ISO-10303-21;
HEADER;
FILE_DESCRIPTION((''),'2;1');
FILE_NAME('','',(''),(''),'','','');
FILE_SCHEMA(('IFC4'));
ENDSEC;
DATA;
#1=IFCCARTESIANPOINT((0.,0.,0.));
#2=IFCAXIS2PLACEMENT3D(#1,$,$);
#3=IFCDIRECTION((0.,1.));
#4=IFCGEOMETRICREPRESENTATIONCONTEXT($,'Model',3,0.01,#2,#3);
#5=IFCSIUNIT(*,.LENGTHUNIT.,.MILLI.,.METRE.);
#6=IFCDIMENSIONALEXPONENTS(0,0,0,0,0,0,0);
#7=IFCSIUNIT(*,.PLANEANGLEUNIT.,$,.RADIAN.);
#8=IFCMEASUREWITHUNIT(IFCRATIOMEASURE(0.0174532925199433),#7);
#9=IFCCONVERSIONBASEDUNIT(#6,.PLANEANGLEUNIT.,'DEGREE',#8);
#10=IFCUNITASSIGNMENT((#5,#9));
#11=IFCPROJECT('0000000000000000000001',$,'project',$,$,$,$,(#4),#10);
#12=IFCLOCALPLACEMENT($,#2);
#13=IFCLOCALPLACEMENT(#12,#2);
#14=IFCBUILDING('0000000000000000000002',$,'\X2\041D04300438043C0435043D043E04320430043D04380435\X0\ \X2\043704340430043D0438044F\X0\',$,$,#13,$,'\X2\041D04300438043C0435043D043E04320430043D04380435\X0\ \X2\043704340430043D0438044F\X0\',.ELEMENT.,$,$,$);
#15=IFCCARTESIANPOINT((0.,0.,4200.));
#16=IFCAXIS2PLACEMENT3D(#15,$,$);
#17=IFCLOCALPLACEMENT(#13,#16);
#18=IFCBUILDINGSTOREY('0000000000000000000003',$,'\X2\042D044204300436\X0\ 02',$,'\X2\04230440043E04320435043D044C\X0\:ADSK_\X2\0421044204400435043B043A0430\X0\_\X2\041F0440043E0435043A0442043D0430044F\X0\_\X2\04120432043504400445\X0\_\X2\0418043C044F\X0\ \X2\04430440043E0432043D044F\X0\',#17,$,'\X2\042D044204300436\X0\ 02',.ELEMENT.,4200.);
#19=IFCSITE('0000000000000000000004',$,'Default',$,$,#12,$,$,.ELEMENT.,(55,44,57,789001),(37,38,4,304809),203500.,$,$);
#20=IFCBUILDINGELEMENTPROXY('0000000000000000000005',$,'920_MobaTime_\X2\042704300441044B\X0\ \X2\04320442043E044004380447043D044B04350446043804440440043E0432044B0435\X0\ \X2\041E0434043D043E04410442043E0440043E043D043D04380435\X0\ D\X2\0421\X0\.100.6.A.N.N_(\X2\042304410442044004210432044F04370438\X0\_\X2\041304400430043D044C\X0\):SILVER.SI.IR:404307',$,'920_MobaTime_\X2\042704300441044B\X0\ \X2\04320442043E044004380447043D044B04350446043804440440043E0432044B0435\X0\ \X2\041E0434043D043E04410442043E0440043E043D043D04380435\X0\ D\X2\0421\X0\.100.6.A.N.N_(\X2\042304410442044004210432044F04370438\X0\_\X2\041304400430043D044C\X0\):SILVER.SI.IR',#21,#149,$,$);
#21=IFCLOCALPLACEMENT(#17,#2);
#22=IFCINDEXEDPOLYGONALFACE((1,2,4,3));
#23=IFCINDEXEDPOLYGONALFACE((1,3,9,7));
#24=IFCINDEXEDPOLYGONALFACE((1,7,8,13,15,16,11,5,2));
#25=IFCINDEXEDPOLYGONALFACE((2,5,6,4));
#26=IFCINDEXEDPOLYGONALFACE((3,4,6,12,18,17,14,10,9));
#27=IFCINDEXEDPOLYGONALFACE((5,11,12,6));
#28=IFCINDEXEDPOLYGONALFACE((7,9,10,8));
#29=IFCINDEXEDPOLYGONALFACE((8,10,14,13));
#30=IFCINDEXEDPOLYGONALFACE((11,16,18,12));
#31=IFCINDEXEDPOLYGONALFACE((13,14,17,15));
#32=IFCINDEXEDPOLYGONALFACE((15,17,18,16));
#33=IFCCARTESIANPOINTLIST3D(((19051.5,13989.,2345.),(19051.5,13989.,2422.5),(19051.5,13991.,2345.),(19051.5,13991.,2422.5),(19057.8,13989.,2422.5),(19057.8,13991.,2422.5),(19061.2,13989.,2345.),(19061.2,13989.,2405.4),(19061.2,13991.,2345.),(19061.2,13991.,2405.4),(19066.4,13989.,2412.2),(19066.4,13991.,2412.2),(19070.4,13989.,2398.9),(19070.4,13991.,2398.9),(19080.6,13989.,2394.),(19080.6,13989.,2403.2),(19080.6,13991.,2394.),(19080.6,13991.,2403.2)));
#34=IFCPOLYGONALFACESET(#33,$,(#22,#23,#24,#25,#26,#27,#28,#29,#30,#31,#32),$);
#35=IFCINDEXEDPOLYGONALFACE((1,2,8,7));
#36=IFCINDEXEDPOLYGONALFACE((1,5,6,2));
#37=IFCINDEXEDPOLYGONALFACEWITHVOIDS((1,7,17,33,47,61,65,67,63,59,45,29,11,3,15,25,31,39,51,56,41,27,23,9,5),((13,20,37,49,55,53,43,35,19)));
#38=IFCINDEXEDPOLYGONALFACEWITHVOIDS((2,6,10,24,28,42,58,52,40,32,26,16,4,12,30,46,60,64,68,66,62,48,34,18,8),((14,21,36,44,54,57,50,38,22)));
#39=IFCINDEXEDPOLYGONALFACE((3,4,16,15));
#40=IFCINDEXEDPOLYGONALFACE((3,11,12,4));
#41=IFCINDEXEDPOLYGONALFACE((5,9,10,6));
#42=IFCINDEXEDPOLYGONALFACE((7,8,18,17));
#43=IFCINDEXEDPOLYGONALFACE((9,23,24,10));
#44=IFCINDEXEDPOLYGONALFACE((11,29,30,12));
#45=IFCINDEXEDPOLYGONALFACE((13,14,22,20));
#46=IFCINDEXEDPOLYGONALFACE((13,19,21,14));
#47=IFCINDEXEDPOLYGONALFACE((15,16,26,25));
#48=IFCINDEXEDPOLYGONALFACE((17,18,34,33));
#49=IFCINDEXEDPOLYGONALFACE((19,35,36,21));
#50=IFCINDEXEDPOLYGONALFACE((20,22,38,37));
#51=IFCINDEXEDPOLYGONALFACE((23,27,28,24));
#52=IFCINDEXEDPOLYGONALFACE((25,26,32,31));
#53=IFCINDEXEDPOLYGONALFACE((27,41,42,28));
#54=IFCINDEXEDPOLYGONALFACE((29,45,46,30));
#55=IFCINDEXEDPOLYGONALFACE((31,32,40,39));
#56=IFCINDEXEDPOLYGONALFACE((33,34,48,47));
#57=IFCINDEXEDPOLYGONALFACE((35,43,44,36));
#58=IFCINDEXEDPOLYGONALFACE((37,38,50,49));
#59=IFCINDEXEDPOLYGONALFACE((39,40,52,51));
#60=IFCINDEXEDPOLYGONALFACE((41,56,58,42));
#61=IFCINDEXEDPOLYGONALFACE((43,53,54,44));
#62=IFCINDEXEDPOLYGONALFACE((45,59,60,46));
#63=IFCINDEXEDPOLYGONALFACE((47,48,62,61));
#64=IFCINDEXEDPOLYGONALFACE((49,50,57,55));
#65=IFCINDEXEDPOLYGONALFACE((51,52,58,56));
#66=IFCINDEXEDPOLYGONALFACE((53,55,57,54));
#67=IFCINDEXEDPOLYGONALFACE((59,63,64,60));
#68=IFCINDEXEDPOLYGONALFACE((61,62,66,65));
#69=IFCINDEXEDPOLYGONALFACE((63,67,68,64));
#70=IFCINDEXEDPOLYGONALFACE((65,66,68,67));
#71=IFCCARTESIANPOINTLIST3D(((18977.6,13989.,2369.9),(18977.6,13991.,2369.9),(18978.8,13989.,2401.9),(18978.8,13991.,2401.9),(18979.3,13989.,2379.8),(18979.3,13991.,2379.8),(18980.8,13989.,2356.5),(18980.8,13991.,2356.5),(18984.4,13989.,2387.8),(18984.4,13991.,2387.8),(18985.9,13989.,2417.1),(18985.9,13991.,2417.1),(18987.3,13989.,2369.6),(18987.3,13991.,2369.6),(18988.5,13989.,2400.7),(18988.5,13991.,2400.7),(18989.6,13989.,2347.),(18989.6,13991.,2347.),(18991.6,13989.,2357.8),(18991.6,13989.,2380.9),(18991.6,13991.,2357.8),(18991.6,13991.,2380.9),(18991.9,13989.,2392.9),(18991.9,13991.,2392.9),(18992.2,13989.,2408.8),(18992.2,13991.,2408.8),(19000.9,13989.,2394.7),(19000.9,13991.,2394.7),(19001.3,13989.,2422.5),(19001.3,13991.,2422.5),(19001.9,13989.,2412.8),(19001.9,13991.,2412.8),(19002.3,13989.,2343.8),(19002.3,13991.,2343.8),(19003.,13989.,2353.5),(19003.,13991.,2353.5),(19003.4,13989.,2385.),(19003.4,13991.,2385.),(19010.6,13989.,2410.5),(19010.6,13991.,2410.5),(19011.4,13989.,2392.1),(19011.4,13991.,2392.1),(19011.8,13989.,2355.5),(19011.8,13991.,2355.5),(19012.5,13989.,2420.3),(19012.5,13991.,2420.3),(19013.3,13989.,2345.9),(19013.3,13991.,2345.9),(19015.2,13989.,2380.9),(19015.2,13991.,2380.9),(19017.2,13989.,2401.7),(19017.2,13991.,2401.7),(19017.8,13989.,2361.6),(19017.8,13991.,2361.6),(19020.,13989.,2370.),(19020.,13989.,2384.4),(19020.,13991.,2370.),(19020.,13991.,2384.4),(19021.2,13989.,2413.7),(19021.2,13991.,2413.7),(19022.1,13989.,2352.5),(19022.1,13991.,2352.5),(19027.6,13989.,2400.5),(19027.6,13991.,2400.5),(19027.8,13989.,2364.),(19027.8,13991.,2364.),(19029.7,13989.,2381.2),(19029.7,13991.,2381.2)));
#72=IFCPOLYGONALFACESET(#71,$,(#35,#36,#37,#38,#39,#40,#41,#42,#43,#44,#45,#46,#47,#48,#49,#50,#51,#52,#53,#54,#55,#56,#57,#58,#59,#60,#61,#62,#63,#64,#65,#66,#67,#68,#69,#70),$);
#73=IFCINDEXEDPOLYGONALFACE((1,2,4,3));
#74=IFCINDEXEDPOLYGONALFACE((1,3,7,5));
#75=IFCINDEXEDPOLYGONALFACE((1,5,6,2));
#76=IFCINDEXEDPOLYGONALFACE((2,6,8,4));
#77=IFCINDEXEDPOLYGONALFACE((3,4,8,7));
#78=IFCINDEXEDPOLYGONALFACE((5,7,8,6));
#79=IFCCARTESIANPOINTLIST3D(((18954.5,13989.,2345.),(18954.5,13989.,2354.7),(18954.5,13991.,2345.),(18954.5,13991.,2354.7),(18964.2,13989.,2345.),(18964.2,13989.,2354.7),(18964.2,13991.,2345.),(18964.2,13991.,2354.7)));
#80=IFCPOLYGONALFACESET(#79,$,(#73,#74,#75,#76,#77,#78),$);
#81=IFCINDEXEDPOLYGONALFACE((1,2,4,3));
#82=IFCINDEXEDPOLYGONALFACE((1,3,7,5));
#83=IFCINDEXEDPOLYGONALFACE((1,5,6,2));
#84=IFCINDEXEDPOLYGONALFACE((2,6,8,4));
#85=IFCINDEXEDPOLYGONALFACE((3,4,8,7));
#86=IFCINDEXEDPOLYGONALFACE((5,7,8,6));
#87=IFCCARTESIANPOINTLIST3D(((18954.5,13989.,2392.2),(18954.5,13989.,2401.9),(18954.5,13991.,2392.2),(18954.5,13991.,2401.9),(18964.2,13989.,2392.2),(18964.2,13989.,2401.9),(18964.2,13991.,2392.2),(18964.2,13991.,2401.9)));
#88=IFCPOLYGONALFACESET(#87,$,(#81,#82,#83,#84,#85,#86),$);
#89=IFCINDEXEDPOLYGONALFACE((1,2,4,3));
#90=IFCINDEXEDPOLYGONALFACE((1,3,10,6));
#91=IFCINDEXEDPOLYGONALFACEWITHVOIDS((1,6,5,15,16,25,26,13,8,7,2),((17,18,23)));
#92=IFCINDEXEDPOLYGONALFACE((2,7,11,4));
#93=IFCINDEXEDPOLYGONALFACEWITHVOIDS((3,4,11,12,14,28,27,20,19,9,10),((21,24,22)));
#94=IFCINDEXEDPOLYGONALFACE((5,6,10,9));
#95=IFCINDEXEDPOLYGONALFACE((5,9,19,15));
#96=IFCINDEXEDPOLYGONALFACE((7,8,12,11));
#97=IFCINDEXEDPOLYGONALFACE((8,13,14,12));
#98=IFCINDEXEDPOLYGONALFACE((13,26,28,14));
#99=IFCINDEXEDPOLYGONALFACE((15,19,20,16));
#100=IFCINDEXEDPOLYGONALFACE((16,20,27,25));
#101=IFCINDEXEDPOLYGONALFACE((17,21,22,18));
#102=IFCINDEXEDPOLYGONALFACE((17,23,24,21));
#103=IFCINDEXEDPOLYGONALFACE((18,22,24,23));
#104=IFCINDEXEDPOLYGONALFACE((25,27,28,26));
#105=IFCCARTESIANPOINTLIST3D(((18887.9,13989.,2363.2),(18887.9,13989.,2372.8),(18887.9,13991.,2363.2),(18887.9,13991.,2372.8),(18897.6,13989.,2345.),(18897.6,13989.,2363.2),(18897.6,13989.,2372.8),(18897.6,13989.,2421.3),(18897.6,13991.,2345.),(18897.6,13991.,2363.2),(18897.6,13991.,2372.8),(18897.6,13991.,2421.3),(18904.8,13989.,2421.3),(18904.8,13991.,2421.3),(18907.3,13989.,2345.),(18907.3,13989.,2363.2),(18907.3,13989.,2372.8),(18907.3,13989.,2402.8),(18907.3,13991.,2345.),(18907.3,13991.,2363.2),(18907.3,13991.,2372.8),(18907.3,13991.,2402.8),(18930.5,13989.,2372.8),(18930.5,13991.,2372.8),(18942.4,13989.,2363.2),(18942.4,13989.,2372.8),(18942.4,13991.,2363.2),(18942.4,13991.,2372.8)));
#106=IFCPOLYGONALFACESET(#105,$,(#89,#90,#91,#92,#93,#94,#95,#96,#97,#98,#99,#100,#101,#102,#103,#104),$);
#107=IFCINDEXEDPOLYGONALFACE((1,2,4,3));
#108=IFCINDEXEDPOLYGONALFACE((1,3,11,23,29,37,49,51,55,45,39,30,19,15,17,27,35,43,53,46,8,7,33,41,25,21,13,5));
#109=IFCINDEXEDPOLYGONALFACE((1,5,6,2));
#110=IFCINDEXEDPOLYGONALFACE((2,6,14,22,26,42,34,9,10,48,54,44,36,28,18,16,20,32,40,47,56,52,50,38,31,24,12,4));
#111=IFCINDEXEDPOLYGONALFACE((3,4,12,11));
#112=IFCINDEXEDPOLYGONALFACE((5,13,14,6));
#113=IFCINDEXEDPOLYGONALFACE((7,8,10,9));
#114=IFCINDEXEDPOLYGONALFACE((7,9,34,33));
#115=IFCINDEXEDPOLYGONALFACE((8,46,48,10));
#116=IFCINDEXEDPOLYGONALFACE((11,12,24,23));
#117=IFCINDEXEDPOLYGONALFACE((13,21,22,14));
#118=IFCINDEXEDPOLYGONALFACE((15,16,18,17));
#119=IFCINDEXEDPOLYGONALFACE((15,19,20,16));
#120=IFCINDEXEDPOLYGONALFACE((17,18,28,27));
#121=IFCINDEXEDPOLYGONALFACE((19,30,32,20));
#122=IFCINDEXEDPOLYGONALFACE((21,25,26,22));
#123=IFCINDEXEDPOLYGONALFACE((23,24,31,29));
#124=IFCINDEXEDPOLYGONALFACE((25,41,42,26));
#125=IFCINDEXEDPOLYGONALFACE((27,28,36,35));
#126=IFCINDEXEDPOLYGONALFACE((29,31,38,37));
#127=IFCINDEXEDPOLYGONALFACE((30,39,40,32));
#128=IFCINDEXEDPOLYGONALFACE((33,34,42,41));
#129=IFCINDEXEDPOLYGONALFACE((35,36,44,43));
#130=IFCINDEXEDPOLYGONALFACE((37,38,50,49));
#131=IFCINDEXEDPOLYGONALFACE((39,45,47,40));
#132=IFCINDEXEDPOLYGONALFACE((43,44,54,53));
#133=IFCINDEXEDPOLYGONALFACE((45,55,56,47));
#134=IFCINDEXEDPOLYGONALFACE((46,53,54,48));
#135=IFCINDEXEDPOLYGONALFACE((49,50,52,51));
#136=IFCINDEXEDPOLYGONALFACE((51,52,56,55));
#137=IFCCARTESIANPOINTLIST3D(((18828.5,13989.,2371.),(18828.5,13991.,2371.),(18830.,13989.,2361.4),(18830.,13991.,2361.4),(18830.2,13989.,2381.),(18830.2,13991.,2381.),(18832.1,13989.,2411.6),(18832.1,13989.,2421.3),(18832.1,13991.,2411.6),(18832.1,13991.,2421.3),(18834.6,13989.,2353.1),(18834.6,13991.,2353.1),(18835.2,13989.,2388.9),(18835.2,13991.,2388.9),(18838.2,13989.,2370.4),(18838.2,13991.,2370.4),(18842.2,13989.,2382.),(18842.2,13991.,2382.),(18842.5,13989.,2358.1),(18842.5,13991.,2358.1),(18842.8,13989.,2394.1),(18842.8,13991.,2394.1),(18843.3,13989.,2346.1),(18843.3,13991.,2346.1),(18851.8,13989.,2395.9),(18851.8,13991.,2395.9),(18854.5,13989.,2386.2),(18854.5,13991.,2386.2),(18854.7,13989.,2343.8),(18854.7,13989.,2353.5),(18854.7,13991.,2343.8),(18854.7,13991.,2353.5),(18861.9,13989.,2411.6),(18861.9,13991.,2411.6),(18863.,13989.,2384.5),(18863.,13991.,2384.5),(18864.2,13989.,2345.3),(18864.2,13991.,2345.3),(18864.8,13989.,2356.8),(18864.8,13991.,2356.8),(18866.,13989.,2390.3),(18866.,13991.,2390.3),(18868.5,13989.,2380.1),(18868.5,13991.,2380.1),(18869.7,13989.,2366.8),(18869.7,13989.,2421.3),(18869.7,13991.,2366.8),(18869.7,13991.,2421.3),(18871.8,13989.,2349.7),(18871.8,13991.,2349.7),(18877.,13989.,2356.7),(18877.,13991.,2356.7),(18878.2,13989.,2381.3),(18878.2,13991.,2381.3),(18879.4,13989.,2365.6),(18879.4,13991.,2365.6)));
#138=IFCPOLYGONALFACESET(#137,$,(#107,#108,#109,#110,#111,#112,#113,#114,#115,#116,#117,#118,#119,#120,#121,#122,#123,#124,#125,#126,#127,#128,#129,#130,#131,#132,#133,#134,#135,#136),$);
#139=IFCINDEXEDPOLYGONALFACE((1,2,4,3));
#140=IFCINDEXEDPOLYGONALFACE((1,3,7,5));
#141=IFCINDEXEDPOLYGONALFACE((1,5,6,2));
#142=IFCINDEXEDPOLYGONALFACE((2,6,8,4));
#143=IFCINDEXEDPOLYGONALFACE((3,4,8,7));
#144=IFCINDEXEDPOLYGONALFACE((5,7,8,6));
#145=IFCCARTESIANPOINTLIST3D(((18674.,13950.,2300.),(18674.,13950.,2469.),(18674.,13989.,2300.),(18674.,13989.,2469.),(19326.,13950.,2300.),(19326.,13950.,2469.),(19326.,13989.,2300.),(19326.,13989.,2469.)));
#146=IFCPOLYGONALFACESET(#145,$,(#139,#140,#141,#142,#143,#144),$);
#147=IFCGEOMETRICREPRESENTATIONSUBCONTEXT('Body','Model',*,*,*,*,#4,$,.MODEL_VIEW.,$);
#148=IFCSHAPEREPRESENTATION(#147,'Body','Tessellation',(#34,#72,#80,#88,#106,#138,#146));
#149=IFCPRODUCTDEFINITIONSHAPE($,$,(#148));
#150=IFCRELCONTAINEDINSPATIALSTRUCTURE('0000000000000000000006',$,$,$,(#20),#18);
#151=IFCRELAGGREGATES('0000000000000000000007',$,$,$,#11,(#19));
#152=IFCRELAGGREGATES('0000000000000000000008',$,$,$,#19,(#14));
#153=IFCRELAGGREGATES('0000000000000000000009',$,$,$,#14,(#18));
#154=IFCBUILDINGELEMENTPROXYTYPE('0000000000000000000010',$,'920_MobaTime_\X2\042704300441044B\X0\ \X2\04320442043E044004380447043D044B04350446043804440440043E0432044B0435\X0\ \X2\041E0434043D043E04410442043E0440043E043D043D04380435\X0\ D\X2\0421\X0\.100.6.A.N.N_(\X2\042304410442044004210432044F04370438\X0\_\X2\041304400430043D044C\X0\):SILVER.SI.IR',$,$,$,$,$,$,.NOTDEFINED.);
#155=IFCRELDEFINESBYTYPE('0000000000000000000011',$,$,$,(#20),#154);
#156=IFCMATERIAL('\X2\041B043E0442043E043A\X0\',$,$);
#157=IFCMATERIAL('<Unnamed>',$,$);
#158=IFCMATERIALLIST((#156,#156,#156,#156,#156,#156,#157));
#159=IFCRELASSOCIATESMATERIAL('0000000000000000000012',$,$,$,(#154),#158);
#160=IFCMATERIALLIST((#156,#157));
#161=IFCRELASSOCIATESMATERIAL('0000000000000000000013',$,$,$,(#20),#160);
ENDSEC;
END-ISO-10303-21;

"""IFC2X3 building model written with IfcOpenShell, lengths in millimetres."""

from ifc_helpers import new_model, entity, si_unit, converted_unit, direction, frame, origin, origin_2d_with_axis, place, context, subcontext, project, spatial, polyline, rectangle, outline, extrude, source, transform, mapped, material, material_list, type_object, type_shapes, element, save


model = new_model("IFC2X3")

# Units and contexts
model_context = context("Model", 3, precision=0.01, world=origin(), true_north=direction((0.0, 1.0)))
body_context = subcontext(model_context, "Body", "Model", "MODEL_VIEW")
ifc_project = project(units=[si_unit("LENGTHUNIT", "METRE", prefix="MILLI"), converted_unit("PLANEANGLEUNIT", "DEGREE", entity("IfcRatioMeasure", 0.0174532925199433), si_unit("PLANEANGLEUNIT", "RADIAN"), dimensions=[0, 0, 0, 0, 0, 0, 0])], contexts=[model_context])

# Site, building, storey
site_placement = place(None, frame((0.0, 0.0, 0.0)))
site = spatial("IfcSite", under=ifc_project, at=site_placement, Name="Default", CompositionType="ELEMENT", RefLatitude=(55, 44, 57, 789001), RefLongitude=(37, 38, 4, 304809), RefElevation=203500.0)
building_placement = place(site_placement, origin())
building = spatial("IfcBuilding", under=site, at=building_placement, Name="Наименование здания", LongName="Наименование здания", CompositionType="ELEMENT")
storey_placement = place(building_placement, frame((0.0, 0.0, 4200.0)))
storey = spatial("IfcBuildingStorey", under=building, at=storey_placement, Name="Этаж 02", ObjectType="Уровень:ADSK_Стрелка_Проектная_Вверх_Имя уровня", LongName="Этаж 02", CompositionType="ELEMENT", Elevation=4200.0)

# Building element proxy
ifc_material_1 = material(Name="Лоток")
ifc_material_2 = material(Name="<Unnamed>")
ifc_material_list_1 = material_list([ifc_material_1, ifc_material_1, ifc_material_1, ifc_material_1, ifc_material_1, ifc_material_1, ifc_material_2])
building_element_proxy_type_1 = type_object("IfcBuildingElementProxyType", Name="920_MobaTime_Часы вторичныецифровые Односторонние DС.100.6.A.N.N_(УстрСвязи_Грань):SILVER.SI.IR", PredefinedType="NOTDEFINED", material=ifc_material_list_1)
shared_shape_1 = source(origin(), body_context, "Body", "SweptSolid", [
    extrude(outline(polyline([(-49.3, -13.1), (28.2, -13.1), (28.2, -6.8), (17.9, 1.8), (8.9, 16.0), (-0.3, 16.0), (4.6, 5.8), (11.1, -3.4), (-49.3, -3.4), (-49.3, -13.1)])), frame((-64.6, 9.8, 39.0), z_axis=(0.0, 0.0, 1.0), x_axis=(0.0, 1.0, 0.0)), (0.0, 0.0, 1.0), 2.0),
    extrude(outline(polyline([(2.2, -27.6), (19.0, -27.6), (30.5, -16.1), (33.3, -4.9), (31.0, 5.8), (21.8, 17.2), (5.2, 27.3), (-11.1, 33.0), (-24.0, 32.7), (-33.6, 27.6), (-40.3, 18.6), (-42.8, 5.7), (-38.0, -6.3), (-27.2, -15.0), (-17.5, -17.7), (-8.2, -16.4), (-0.3, -11.9), (5.1, -4.5), (7.3, 6.2), (4.0, 17.2), (18.5, 7.3), (23.6, -2.4), (22.0, -11.4), (14.2, -18.4), (5.3, -18.3), (2.2, -27.6)]), holes=[polyline([(-9.0, 23.3), (-1.3, 14.4), (-2.6, 2.0), (-11.4, -7.0), (-23.4, -6.1), (-32.2, 2.9), (-31.2, 15.1), (-25.6, 22.1), (-17.5, 24.9), (-9.0, 23.3)])]), frame((-2.7, 3.6, 39.0), z_axis=(0.0, 0.0, 1.0), x_axis=(-0.427649, 0.903945, 0.0)), (0.0, 0.0, 1.0), 2.0),
    extrude(rectangle(XDim=9.7, YDim=9.7, at=origin_2d_with_axis()), frame((40.6, -34.7, 39.0)), (0.0, 0.0, 1.0), 2.0),
    extrude(rectangle(XDim=9.7, YDim=9.7, at=origin_2d_with_axis()), frame((40.6, 12.6, 39.0)), (0.0, 0.0, 1.0), 2.0),
    extrude(outline(polyline([(-0.9, -28.1), (8.8, -28.1), (8.8, -9.9), (18.5, -9.9), (18.5, -0.2), (8.8, -0.2), (8.8, 48.3), (1.5, 48.3), (-36.0, -0.2), (-36.0, -9.9), (-0.9, -9.9), (-0.9, -28.1)]), holes=[polyline([(-0.9, -0.2), (-24.1, -0.2), (-0.9, 29.7), (-0.9, -0.2)])]), frame((93.6, -11.4, 39.0)), (0.0, 0.0, 1.0), 2.0),
    extrude(outline(polyline([(3.3, -28.3), (12.5, -28.3), (20.5, -25.0), (26.8, -18.8), (30.7, -10.0), (31.4, 1.6), (26.9, 11.8), (20.1, 18.4), (11.1, 22.3), (1.0, 23.3), (-7.9, 20.4), (-14.9, 14.5), (-18.9, 6.2), (-17.1, -9.0), (-36.7, 0.5), (-29.1, 29.3), (-38.5, 31.7), (-48.1, -4.6), (-11.6, -23.0), (-8.0, -14.0), (-10.8, -7.6), (-10.2, 1.1), (-3.0, 11.8), (9.2, 12.8), (20.0, 5.4), (21.3, -7.5), (15.5, -16.4), (4.6, -18.6), (3.3, -28.3)])), frame((147.1, -8.5, 39.0), z_axis=(0.0, 0.0, 1.0), x_axis=(0.256974, -0.966418, 0.0)), (0.0, 0.0, 1.0), 2.0),
    extrude(rectangle(XDim=652.0, YDim=169.0, at=origin_2d_with_axis()), frame((0.0, 0.0, 0.0), z_axis=(0.0, 0.0, 1.0), x_axis=(-1.0, 0.0, 0.0)), (0.0, 0.0, 1.0), 39.0),
])
type_shapes(building_element_proxy_type_1, [shared_shape_1])
ifc_material_list_2 = material_list([ifc_material_1, ifc_material_2])
proxy_1_placement = place(storey_placement, frame((19000.0, 13950.0, 2384.5), z_axis=(0.0, 1.0, 0.0), x_axis=(-1.0, 0.0, 0.0)))
element("IfcBuildingElementProxy", 1, at=proxy_1_placement, inside=storey, type_object=building_element_proxy_type_1, material=ifc_material_list_2, Name="920_MobaTime_Часы вторичныецифровые Односторонние DС.100.6.A.N.N_(УстрСвязи_Грань):SILVER.SI.IR:404307", ObjectType="920_MobaTime_Часы вторичныецифровые Односторонние DС.100.6.A.N.N_(УстрСвязи_Грань):SILVER.SI.IR", context=body_context, shape_type="MappedRepresentation", body=[
    mapped(shared_shape_1, transform((0.0, 0.0, 0.0), scale=1.0)),
])

save(model, "model.ifc")
